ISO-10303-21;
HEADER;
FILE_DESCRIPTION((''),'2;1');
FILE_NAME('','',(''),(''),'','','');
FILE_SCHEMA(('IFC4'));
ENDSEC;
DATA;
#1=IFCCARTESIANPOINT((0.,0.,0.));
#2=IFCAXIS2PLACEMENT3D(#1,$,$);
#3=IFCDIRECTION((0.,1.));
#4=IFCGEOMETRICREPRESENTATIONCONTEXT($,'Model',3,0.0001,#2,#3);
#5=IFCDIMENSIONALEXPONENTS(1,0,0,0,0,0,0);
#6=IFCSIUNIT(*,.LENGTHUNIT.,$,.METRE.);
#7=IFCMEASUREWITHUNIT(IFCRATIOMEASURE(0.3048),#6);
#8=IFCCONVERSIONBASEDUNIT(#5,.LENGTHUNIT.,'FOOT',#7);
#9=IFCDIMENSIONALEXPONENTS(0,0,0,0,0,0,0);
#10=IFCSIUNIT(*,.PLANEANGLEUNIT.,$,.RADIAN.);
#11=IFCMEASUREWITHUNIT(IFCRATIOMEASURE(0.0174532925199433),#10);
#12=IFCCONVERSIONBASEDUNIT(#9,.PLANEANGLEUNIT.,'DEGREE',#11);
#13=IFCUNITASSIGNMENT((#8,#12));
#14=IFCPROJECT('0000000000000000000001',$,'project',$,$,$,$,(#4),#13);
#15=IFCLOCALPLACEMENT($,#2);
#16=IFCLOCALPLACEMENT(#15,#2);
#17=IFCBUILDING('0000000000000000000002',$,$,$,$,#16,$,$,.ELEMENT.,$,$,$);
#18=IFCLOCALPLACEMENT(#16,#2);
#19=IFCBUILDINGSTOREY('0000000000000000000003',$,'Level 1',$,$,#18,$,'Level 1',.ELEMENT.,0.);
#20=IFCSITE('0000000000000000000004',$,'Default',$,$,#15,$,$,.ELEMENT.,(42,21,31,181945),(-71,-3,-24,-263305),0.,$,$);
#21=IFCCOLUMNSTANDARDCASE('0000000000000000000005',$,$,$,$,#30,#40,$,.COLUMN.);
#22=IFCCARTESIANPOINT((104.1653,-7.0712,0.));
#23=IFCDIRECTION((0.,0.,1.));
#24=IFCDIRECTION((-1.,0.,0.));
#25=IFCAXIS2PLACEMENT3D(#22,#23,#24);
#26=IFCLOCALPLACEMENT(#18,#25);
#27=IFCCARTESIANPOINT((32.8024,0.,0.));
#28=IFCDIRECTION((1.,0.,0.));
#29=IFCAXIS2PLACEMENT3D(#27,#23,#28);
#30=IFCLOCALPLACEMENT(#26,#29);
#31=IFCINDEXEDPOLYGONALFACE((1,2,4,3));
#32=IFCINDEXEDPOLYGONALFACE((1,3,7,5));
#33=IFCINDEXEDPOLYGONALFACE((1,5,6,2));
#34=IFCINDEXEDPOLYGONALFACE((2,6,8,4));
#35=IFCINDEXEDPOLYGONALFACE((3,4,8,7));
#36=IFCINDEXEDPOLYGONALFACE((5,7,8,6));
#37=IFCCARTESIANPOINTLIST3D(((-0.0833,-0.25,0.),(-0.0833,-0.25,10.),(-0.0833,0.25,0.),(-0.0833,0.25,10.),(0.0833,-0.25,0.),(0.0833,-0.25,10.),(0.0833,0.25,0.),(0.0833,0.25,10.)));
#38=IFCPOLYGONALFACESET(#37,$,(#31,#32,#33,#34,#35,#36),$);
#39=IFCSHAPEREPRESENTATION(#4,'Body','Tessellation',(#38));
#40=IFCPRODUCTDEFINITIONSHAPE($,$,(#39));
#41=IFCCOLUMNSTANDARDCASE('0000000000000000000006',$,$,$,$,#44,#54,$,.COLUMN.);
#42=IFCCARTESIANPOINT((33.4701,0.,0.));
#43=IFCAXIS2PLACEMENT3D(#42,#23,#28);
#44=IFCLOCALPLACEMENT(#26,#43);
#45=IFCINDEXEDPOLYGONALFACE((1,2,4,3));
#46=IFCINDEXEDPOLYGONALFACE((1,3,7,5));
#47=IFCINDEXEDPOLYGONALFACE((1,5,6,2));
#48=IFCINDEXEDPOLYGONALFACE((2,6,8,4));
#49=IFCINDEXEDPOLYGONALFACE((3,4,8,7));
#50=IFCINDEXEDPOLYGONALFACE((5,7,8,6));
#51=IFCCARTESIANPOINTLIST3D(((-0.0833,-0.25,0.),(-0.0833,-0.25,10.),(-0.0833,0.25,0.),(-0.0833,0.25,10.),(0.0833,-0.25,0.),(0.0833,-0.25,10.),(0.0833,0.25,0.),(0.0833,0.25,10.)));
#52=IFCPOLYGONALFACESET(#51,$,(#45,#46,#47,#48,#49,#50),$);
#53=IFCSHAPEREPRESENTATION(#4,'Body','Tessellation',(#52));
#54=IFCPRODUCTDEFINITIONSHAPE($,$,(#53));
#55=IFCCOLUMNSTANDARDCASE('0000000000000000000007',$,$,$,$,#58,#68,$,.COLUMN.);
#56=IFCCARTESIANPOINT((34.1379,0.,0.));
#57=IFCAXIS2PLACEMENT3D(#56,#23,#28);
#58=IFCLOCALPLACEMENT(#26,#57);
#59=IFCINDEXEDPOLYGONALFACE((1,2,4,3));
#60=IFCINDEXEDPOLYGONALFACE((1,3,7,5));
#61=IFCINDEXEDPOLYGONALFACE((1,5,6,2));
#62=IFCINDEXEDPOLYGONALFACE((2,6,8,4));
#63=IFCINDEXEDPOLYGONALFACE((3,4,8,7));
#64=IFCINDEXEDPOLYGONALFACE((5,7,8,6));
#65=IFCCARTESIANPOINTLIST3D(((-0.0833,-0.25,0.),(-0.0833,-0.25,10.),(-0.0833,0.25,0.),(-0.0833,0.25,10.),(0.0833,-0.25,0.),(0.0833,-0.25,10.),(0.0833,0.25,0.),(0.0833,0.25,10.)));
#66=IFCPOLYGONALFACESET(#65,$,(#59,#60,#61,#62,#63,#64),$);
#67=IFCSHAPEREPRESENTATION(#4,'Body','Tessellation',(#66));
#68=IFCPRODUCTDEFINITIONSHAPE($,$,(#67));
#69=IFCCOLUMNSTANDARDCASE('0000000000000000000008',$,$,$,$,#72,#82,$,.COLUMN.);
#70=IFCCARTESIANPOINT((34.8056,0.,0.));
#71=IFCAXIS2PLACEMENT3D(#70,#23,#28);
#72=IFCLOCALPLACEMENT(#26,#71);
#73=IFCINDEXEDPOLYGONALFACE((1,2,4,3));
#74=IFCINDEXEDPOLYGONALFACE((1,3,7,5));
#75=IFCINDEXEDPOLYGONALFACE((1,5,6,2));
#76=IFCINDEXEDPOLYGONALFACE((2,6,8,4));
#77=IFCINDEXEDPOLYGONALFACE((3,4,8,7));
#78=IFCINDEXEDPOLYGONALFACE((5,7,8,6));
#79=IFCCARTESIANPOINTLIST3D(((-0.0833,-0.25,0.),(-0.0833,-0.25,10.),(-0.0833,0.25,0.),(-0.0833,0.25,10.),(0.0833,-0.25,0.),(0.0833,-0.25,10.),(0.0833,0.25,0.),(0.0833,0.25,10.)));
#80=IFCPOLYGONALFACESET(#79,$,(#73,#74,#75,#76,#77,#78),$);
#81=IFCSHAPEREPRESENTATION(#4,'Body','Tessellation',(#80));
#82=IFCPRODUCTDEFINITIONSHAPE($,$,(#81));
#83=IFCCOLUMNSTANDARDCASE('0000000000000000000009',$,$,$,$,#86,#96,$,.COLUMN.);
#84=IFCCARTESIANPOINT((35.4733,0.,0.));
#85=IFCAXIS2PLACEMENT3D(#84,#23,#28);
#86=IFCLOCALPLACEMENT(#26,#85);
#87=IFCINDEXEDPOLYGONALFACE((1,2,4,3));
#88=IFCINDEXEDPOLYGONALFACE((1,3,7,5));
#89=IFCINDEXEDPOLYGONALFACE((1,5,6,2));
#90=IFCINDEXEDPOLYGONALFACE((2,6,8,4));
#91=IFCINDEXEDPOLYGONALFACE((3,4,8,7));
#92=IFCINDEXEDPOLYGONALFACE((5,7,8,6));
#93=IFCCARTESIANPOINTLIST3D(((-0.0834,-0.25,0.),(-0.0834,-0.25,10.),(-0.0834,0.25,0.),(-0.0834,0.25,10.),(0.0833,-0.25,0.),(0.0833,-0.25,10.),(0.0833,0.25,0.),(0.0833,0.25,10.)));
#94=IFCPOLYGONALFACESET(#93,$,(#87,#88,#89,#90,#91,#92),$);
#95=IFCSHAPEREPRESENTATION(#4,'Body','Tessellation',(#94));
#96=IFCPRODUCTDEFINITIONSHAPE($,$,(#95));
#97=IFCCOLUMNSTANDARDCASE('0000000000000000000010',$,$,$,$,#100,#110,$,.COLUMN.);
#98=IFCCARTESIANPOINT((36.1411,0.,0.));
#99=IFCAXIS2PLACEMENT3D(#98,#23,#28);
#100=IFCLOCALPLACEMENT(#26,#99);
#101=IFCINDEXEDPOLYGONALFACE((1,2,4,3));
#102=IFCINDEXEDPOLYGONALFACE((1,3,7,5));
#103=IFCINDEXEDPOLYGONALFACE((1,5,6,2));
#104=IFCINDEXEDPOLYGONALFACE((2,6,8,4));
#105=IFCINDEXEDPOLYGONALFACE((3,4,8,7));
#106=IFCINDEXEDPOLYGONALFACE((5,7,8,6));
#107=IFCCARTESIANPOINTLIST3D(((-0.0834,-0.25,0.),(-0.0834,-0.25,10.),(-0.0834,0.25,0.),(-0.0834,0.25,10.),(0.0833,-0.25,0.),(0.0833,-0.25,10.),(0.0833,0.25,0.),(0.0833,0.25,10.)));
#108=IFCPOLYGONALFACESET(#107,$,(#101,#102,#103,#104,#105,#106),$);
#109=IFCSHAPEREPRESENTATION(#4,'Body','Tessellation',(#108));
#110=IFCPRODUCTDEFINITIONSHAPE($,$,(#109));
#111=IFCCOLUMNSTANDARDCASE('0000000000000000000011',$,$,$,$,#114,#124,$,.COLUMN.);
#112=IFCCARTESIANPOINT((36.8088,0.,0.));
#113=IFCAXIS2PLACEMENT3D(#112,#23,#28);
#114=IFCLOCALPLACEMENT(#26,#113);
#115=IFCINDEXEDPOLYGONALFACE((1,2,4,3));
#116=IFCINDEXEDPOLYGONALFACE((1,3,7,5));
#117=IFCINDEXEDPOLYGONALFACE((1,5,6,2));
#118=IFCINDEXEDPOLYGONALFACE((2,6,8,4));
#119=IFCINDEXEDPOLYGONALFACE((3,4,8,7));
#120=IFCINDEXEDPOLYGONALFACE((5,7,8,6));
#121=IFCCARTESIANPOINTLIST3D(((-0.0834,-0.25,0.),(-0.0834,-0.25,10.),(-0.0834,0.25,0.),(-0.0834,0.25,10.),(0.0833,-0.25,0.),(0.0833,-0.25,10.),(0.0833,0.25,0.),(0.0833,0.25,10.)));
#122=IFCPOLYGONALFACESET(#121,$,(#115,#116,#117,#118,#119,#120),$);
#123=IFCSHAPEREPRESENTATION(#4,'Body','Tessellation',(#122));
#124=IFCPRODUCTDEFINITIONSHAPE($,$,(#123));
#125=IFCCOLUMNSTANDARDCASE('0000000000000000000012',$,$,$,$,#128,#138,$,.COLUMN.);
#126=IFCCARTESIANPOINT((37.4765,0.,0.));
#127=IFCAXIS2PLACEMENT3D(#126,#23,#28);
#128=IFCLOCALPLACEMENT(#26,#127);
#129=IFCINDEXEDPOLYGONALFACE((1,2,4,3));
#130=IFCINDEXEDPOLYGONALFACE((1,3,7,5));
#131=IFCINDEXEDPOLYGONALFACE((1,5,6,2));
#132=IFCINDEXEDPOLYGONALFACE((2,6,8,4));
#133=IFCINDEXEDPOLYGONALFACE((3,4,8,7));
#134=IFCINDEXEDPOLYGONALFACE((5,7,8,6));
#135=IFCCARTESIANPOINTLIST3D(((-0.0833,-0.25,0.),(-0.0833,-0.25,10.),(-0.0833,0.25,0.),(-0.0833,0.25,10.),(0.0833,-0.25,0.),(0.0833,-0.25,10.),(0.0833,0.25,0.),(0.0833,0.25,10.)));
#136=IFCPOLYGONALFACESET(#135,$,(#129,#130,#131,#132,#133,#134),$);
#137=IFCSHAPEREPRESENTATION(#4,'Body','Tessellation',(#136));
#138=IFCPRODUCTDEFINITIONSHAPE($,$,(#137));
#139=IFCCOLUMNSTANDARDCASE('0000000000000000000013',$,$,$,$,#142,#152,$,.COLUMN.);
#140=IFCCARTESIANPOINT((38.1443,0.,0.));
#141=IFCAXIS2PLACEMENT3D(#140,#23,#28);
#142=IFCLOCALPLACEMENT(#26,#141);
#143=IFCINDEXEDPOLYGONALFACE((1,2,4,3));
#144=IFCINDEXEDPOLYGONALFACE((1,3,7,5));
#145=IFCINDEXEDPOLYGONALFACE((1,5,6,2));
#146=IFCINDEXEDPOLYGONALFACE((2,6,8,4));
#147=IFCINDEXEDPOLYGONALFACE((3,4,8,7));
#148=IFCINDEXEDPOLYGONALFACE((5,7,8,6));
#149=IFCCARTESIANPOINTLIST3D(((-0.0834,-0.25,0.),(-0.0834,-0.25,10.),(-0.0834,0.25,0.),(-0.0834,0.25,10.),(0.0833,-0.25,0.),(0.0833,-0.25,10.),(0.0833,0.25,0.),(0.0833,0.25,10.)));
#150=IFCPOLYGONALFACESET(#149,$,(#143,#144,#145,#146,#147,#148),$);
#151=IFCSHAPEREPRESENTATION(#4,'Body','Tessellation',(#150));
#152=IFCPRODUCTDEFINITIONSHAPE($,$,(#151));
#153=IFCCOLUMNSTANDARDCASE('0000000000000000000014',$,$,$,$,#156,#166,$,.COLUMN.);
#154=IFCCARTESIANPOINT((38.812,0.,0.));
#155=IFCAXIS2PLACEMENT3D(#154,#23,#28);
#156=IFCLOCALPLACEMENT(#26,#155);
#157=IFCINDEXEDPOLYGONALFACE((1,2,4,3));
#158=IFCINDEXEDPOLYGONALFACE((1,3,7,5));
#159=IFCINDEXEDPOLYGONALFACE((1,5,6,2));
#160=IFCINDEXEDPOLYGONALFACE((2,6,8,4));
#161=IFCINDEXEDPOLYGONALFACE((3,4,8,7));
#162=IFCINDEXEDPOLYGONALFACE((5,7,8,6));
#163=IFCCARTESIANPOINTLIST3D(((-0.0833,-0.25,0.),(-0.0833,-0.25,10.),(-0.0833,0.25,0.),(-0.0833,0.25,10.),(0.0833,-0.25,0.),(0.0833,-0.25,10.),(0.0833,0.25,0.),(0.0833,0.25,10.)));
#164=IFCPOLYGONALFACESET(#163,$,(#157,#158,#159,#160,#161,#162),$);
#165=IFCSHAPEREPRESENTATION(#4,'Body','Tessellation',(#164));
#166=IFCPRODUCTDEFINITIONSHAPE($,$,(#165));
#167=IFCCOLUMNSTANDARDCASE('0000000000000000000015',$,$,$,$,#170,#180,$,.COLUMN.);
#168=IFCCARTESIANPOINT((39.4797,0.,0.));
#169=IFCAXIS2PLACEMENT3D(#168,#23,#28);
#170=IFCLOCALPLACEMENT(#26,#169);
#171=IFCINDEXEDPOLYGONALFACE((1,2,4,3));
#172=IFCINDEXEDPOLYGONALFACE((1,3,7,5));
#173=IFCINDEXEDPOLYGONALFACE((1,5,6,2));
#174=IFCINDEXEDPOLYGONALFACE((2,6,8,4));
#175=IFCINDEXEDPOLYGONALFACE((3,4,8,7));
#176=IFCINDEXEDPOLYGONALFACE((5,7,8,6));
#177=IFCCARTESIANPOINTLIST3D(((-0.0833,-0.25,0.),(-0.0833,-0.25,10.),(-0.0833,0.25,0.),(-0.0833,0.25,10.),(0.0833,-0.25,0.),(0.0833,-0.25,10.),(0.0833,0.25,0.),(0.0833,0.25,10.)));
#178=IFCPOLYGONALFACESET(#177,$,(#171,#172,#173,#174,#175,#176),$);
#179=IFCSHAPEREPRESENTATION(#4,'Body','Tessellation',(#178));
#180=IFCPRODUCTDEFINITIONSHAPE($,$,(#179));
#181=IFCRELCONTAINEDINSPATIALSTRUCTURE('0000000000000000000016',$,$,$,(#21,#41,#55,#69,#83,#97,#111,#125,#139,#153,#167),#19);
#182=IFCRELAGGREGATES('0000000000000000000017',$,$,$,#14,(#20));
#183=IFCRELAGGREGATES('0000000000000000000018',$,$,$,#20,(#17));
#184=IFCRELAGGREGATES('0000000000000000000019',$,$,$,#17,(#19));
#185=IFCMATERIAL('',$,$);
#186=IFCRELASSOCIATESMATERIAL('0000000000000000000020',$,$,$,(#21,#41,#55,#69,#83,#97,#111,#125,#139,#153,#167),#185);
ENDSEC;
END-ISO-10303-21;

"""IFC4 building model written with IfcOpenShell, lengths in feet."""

from ifc_helpers import new_model, entity, si_unit, converted_unit, direction, frame, origin, place, context, project, spatial, rectangle, extrude, material, element, save


model = new_model("IFC4")

# Units and contexts
model_context = context("Model", 3, precision=0.0001, world=origin(), true_north=direction((0.0, 1.0)))
ifc_project = project(units=[converted_unit("LENGTHUNIT", "FOOT", entity("IfcRatioMeasure", 0.3048), si_unit("LENGTHUNIT", "METRE"), dimensions=[1, 0, 0, 0, 0, 0, 0]), converted_unit("PLANEANGLEUNIT", "DEGREE", entity("IfcRatioMeasure", 0.0174532925199433), si_unit("PLANEANGLEUNIT", "RADIAN"), dimensions=[0, 0, 0, 0, 0, 0, 0])], contexts=[model_context])

# Site, building, storey
site_placement = place(None, origin())
site = spatial("IfcSite", under=ifc_project, at=site_placement, Name="Default", CompositionType="ELEMENT", RefLatitude=(42, 21, 31, 181945), RefLongitude=(-71, -3, -24, -263305), RefElevation=0.0)
building_placement = place(site_placement, origin())
building = spatial("IfcBuilding", under=site, at=building_placement, CompositionType="ELEMENT")
storey_placement = place(building_placement, origin())
storey = spatial("IfcBuildingStorey", under=building, at=storey_placement, Name="Level 1", LongName="Level 1", CompositionType="ELEMENT", Elevation=0.0)

# Columns
ifc_material_1 = material(Name="")
placement_1 = place(storey_placement, frame((104.1653, -7.0712, 0.0), z_axis=(0.0, 0.0, 1.0), x_axis=(-1.0, 0.0, 0.0)))
for number, where, z_axis, x_axis in (
    (1, (32.8024, 0.0, 0.0), (0.0, 0.0, 1.0), (1.0, 0.0, 0.0)),
    (2, (33.4701, 0.0, 0.0), (0.0, 0.0, 1.0), (1.0, 0.0, 0.0)),
    (3, (34.1379, 0.0, 0.0), (0.0, 0.0, 1.0), (1.0, 0.0, 0.0)),
    (4, (34.8056, 0.0, 0.0), (0.0, 0.0, 1.0), (1.0, 0.0, 0.0)),
    (5, (35.4733, 0.0, 0.0), (0.0, 0.0, 1.0), (1.0, 0.0, 0.0)),
    (6, (36.1411, 0.0, 0.0), (0.0, 0.0, 1.0), (1.0, 0.0, 0.0)),
    (7, (36.8088, 0.0, 0.0), (0.0, 0.0, 1.0), (1.0, 0.0, 0.0)),
    (8, (37.4765, 0.0, 0.0), (0.0, 0.0, 1.0), (1.0, 0.0, 0.0)),
    (9, (38.1443, 0.0, 0.0), (0.0, 0.0, 1.0), (1.0, 0.0, 0.0)),
    (10, (38.812, 0.0, 0.0), (0.0, 0.0, 1.0), (1.0, 0.0, 0.0)),
    (11, (39.4797, 0.0, 0.0), (0.0, 0.0, 1.0), (1.0, 0.0, 0.0)),
):
    element("IfcColumnStandardCase", number, at=place(placement_1, frame(where, z_axis=z_axis, x_axis=x_axis)), inside=storey, material=ifc_material_1, PredefinedType="COLUMN", context=model_context, shape_type="SweptSolid", body=[
        extrude(rectangle(XDim=0.1667, YDim=0.5), origin(), (0.0, 0.0, 1.0), 10.0),
    ])

save(model, "model.ifc")
